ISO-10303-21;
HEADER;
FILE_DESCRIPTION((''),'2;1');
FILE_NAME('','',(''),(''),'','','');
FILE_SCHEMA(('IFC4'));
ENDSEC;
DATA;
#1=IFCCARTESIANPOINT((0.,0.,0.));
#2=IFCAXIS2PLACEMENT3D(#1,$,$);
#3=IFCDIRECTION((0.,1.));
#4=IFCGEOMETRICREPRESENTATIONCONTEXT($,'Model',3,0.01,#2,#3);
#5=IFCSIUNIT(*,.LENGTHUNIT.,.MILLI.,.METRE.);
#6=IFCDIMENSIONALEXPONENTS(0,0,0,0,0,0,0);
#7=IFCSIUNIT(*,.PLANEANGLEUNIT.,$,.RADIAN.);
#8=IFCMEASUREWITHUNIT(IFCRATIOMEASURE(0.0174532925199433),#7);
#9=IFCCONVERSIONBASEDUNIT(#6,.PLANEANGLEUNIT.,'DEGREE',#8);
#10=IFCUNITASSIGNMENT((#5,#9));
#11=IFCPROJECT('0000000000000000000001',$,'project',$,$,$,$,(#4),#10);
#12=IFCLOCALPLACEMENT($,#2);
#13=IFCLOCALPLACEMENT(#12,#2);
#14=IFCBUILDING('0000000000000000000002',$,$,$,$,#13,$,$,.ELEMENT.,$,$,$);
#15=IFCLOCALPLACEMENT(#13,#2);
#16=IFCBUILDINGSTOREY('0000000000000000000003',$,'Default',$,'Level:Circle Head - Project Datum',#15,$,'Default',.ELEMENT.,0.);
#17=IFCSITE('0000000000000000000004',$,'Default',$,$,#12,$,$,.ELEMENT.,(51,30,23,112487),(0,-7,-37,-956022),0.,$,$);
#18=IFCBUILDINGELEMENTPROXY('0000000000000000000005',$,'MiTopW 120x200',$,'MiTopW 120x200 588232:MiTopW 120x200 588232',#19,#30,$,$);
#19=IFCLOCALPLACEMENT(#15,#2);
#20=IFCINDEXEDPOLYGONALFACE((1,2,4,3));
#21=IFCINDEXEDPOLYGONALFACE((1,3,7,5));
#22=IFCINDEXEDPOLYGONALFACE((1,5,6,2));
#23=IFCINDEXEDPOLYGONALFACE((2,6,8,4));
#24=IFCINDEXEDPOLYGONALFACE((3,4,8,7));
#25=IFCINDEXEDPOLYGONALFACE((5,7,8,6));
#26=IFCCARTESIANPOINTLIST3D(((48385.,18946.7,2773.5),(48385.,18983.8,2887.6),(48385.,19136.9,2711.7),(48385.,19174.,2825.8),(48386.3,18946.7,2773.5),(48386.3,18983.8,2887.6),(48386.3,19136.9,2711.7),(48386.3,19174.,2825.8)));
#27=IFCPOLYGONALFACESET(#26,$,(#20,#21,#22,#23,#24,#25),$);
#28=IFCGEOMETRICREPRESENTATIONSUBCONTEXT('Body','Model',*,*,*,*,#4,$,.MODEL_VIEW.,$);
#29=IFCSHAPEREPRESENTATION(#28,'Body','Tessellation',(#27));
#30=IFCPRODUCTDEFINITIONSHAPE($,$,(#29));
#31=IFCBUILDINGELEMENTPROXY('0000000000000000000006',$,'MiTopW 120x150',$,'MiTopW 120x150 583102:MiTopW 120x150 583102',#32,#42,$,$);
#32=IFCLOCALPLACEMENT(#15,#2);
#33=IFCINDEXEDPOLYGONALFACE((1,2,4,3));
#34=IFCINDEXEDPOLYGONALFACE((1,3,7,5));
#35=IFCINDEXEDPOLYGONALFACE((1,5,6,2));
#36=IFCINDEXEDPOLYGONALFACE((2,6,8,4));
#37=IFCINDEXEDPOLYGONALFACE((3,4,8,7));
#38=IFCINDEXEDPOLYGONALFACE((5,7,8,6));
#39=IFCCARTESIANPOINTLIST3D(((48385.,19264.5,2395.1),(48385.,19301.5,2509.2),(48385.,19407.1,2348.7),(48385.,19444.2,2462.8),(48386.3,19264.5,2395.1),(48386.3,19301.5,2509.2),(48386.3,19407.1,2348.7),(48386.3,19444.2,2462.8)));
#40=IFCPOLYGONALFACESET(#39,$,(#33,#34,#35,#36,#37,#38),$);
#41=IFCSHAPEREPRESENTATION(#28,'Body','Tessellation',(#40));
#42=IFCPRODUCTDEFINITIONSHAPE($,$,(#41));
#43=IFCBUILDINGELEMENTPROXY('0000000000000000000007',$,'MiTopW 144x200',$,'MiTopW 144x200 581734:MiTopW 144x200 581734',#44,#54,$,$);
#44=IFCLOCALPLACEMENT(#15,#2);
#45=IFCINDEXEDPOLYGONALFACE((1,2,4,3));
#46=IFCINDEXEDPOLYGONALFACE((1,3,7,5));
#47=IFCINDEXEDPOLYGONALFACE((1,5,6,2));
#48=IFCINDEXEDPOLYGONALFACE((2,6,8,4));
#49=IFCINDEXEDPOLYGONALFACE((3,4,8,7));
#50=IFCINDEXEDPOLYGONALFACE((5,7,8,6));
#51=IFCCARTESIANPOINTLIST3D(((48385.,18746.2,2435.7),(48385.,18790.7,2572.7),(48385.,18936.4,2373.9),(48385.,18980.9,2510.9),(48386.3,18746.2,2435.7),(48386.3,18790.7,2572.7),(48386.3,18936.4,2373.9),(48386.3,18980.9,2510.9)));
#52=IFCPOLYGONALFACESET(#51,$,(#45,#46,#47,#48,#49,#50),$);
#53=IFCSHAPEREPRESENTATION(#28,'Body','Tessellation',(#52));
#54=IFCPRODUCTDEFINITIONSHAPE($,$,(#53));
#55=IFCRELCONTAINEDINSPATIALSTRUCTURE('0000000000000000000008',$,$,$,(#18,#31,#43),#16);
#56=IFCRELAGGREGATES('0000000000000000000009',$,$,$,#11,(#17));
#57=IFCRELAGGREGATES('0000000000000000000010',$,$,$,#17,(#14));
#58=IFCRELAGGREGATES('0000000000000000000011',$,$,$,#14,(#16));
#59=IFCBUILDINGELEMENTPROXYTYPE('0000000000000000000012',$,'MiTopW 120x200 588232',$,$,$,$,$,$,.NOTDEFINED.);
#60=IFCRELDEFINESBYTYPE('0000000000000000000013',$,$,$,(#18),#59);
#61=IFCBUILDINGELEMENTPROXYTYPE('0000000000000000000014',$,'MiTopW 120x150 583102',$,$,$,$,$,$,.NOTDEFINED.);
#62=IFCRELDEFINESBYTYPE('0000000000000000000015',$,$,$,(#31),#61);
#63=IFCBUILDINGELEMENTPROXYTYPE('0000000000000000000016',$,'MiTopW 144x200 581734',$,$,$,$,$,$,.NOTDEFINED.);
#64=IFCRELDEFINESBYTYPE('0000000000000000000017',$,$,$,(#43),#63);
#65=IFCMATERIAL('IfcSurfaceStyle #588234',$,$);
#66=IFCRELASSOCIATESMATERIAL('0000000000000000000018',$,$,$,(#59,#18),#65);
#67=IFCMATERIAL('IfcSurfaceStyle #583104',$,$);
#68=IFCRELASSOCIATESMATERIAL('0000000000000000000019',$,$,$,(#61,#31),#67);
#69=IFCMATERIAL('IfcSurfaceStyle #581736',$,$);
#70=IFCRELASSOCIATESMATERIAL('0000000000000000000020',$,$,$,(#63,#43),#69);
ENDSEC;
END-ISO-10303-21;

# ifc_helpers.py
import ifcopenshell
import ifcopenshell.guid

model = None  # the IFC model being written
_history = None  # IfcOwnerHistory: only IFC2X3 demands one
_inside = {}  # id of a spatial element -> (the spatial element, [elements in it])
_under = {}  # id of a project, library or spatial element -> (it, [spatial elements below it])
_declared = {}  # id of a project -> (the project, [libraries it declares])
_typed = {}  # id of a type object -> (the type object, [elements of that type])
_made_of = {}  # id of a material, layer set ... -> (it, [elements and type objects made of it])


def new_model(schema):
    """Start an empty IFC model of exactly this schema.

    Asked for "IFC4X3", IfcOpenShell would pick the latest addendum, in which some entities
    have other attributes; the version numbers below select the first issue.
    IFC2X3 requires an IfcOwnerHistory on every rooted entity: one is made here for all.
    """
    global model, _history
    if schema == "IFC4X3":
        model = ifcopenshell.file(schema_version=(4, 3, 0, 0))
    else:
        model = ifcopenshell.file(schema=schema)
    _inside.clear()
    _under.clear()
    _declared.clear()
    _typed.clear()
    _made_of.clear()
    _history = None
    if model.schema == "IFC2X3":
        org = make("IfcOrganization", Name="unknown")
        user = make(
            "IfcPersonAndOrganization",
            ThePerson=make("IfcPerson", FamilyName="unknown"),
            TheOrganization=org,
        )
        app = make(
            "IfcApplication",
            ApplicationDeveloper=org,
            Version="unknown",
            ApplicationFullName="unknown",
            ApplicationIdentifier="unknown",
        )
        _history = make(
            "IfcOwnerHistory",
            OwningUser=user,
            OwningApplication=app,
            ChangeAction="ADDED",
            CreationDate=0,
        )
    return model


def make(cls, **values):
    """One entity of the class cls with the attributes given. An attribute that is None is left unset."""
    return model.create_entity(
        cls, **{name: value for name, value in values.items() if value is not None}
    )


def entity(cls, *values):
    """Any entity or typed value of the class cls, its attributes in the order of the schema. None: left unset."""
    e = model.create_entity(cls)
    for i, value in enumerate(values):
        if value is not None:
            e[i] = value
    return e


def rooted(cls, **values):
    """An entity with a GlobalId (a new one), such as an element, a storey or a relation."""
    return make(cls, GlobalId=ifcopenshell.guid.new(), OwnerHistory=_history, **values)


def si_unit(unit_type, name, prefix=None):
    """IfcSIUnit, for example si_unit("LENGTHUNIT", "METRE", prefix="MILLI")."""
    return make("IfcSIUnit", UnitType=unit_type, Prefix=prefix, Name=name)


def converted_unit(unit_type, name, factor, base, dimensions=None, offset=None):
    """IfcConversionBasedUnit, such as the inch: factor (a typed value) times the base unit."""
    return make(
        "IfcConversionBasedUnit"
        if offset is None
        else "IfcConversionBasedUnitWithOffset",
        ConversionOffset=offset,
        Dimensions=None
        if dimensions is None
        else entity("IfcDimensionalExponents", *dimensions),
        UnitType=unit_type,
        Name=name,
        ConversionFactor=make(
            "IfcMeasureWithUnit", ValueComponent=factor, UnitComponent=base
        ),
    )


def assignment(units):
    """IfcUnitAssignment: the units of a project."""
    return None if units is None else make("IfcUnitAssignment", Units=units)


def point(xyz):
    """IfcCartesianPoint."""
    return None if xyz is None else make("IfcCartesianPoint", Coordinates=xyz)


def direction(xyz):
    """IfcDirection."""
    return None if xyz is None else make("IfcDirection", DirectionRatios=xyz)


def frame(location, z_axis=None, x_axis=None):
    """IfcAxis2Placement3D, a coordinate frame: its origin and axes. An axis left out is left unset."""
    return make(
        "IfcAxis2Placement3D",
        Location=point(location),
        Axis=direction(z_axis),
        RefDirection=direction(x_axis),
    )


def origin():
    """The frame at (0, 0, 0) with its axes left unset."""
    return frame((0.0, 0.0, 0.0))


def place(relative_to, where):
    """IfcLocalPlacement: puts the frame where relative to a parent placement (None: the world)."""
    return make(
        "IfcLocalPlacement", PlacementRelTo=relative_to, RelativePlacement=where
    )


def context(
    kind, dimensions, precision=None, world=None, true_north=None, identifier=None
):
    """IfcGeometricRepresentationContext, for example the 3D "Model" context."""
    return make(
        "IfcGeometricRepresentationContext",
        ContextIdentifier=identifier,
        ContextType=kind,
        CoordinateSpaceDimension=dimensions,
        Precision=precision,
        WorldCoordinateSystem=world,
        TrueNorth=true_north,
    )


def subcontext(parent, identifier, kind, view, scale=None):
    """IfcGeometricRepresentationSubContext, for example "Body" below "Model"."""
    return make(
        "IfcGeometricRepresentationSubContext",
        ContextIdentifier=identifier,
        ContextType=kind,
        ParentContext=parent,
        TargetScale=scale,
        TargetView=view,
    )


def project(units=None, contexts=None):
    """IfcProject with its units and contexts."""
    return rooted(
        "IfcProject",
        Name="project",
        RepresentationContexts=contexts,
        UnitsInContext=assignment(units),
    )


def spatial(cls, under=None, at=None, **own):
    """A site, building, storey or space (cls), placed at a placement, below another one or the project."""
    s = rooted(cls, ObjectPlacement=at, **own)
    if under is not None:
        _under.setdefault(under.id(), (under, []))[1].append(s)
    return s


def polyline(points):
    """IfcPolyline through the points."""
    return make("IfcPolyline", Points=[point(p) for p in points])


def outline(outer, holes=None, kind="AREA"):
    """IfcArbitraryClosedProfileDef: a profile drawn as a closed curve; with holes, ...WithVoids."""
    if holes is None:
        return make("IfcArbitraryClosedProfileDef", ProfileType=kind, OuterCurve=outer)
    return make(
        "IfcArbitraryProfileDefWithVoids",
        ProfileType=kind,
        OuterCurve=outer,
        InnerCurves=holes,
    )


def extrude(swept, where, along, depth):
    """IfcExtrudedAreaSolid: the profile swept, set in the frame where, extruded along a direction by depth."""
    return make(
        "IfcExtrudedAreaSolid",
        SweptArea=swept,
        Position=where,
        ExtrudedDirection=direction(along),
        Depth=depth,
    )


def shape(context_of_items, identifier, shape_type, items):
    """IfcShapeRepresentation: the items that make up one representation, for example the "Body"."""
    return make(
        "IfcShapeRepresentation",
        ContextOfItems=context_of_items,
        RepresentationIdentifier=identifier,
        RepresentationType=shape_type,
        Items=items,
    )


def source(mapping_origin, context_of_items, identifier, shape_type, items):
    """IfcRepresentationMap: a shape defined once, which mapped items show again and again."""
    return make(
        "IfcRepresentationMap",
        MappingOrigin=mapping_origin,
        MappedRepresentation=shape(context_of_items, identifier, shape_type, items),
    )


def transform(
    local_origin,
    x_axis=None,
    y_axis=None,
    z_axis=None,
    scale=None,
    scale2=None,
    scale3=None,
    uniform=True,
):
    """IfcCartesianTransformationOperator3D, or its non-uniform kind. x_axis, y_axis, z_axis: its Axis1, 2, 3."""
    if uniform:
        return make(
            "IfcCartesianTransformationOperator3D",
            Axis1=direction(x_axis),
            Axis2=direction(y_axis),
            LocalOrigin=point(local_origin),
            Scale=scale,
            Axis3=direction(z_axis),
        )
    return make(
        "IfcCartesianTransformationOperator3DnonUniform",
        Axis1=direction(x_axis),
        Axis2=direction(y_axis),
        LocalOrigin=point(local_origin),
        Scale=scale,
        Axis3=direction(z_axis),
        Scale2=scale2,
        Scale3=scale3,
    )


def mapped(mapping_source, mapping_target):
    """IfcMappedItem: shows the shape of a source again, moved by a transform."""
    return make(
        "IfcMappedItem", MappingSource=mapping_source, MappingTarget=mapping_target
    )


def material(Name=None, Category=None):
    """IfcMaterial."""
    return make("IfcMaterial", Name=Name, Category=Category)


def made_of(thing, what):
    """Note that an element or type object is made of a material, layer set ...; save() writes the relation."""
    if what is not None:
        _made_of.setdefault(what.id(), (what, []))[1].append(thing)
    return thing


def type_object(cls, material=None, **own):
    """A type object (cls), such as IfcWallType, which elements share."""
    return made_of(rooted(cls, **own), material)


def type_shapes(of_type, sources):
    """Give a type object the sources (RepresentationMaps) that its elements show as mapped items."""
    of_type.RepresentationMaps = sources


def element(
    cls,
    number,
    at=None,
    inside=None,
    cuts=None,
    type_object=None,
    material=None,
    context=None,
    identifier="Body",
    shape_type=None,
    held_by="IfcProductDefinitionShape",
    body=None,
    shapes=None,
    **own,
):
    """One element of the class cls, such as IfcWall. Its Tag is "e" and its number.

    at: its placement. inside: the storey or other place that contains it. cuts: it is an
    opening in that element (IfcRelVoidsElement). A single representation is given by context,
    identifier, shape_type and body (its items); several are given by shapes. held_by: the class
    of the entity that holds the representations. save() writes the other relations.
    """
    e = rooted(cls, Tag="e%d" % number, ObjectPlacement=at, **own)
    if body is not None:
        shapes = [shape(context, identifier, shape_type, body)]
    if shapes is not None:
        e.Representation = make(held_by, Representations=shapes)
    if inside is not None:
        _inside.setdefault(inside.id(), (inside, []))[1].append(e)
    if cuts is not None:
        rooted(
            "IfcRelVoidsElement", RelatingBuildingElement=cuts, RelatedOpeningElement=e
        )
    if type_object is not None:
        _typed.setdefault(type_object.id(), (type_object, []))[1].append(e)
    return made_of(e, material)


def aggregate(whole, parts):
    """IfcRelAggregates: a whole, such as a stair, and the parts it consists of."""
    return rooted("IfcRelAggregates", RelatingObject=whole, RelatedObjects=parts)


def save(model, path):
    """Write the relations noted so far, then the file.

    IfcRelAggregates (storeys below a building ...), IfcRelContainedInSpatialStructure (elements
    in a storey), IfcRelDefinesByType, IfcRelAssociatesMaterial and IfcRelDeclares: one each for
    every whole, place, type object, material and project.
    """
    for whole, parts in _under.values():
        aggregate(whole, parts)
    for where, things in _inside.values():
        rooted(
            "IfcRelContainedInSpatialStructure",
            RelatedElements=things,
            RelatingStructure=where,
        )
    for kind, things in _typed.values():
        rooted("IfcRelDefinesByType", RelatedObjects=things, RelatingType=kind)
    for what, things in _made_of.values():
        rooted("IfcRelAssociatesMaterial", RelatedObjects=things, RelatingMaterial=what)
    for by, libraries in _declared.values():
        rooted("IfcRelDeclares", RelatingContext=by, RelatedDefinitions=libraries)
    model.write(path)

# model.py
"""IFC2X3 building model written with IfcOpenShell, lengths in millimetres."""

from ifc_helpers import new_model, entity, si_unit, converted_unit, direction, frame, origin, place, context, subcontext, project, spatial, polyline, outline, extrude, source, transform, mapped, material, type_object, type_shapes, element, save


model = new_model("IFC2X3")

# Units and contexts
model_context = context("Model", 3, precision=0.01, world=origin(), true_north=direction((0.0, 1.0)))
body_context = subcontext(model_context, "Body", "Model", "MODEL_VIEW")
ifc_project = project(units=[si_unit("LENGTHUNIT", "METRE", prefix="MILLI"), converted_unit("PLANEANGLEUNIT", "DEGREE", entity("IfcRatioMeasure", 0.0174532925199433), si_unit("PLANEANGLEUNIT", "RADIAN"), dimensions=[0, 0, 0, 0, 0, 0, 0])], contexts=[model_context])

# Site, building, storey
site_placement = place(None, origin())
site = spatial("IfcSite", under=ifc_project, at=site_placement, Name="Default", CompositionType="ELEMENT", RefLatitude=(51, 30, 23, 112487), RefLongitude=(0, -7, -37, -956022), RefElevation=0.0)
building_placement = place(site_placement, origin())
building = spatial("IfcBuilding", under=site, at=building_placement, CompositionType="ELEMENT")
storey_placement = place(building_placement, origin())
storey = spatial("IfcBuildingStorey", under=building, at=storey_placement, Name="Default", ObjectType="Level:Circle Head - Project Datum", LongName="Default", CompositionType="ELEMENT", Elevation=0.0)

# Building element proxies
ifc_material_1 = material(Name="IfcSurfaceStyle #588234")
building_element_proxy_type_1 = type_object("IfcBuildingElementProxyType", Name="MiTopW 120x200 588232", PredefinedType="NOTDEFINED", material=ifc_material_1)
shared_shape_1 = source(origin(), body_context, "Body", "SweptSolid", [
    extrude(outline(polyline([(-100.0, -60.0), (100.0, -60.0), (100.0, 60.0), (-100.0, 60.0), (-100.0, -60.0)])), frame((100.0, 60.0, 0.0), z_axis=(0.0, 0.0, 1.0), x_axis=(-1.0, 0.0, 0.0)), (0.0, 0.0, 1.0), 1.3),
])
type_shapes(building_element_proxy_type_1, [shared_shape_1])
proxy_1_placement = place(building_placement, frame((48386.3, 19136.9, 2711.7), z_axis=(-1.0, 0.0, 0.0), x_axis=(0.0, -0.951057, 0.309017)))
element("IfcBuildingElementProxy", 1, at=proxy_1_placement, inside=storey, type_object=building_element_proxy_type_1, material=ifc_material_1, Name="MiTopW 120x200", ObjectType="MiTopW 120x200 588232:MiTopW 120x200 588232", context=body_context, shape_type="MappedRepresentation", body=[
    mapped(shared_shape_1, transform((0.0, 0.0, 0.0), scale=1.0)),
])
ifc_material_2 = material(Name="IfcSurfaceStyle #583104")
building_element_proxy_type_2 = type_object("IfcBuildingElementProxyType", Name="MiTopW 120x150 583102", PredefinedType="NOTDEFINED", material=ifc_material_2)
shared_shape_2 = source(origin(), body_context, "Body", "SweptSolid", [
    extrude(outline(polyline([(-75.0, -60.0), (75.0, -60.0), (75.0, 60.0), (-75.0, 60.0), (-75.0, -60.0)])), frame((75.0, 60.0, 0.0), z_axis=(0.0, 0.0, 1.0), x_axis=(-1.0, 0.0, 0.0)), (0.0, 0.0, 1.0), 1.3),
])
type_shapes(building_element_proxy_type_2, [shared_shape_2])
proxy_2_placement = place(building_placement, frame((48386.3, 19407.1, 2348.7), z_axis=(-1.0, 0.0, 0.0), x_axis=(0.0, -0.951057, 0.309017)))
element("IfcBuildingElementProxy", 2, at=proxy_2_placement, inside=storey, type_object=building_element_proxy_type_2, material=ifc_material_2, Name="MiTopW 120x150", ObjectType="MiTopW 120x150 583102:MiTopW 120x150 583102", context=body_context, shape_type="MappedRepresentation", body=[
    mapped(shared_shape_2, transform((0.0, 0.0, 0.0), scale=1.0)),
])
ifc_material_3 = material(Name="IfcSurfaceStyle #581736")
building_element_proxy_type_3 = type_object("IfcBuildingElementProxyType", Name="MiTopW 144x200 581734", PredefinedType="NOTDEFINED", material=ifc_material_3)
shared_shape_3 = source(origin(), body_context, "Body", "SweptSolid", [
    extrude(outline(polyline([(-100.0, -72.0), (100.0, -72.0), (100.0, 72.0), (-100.0, 72.0), (-100.0, -72.0)])), frame((100.0, 72.0, 0.0), z_axis=(0.0, 0.0, 1.0), x_axis=(-1.0, 0.0, 0.0)), (0.0, 0.0, 1.0), 1.3),
])
type_shapes(building_element_proxy_type_3, [shared_shape_3])
proxy_3_placement = place(building_placement, frame((48386.3, 18936.4, 2373.9), z_axis=(-1.0, 0.0, 0.0), x_axis=(0.0, -0.951057, 0.309017)))
element("IfcBuildingElementProxy", 3, at=proxy_3_placement, inside=storey, type_object=building_element_proxy_type_3, material=ifc_material_3, Name="MiTopW 144x200", ObjectType="MiTopW 144x200 581734:MiTopW 144x200 581734", context=body_context, shape_type="MappedRepresentation", body=[
    mapped(shared_shape_3, transform((0.0, 0.0, 0.0), scale=1.0)),
])

save(model, "model.ifc")
